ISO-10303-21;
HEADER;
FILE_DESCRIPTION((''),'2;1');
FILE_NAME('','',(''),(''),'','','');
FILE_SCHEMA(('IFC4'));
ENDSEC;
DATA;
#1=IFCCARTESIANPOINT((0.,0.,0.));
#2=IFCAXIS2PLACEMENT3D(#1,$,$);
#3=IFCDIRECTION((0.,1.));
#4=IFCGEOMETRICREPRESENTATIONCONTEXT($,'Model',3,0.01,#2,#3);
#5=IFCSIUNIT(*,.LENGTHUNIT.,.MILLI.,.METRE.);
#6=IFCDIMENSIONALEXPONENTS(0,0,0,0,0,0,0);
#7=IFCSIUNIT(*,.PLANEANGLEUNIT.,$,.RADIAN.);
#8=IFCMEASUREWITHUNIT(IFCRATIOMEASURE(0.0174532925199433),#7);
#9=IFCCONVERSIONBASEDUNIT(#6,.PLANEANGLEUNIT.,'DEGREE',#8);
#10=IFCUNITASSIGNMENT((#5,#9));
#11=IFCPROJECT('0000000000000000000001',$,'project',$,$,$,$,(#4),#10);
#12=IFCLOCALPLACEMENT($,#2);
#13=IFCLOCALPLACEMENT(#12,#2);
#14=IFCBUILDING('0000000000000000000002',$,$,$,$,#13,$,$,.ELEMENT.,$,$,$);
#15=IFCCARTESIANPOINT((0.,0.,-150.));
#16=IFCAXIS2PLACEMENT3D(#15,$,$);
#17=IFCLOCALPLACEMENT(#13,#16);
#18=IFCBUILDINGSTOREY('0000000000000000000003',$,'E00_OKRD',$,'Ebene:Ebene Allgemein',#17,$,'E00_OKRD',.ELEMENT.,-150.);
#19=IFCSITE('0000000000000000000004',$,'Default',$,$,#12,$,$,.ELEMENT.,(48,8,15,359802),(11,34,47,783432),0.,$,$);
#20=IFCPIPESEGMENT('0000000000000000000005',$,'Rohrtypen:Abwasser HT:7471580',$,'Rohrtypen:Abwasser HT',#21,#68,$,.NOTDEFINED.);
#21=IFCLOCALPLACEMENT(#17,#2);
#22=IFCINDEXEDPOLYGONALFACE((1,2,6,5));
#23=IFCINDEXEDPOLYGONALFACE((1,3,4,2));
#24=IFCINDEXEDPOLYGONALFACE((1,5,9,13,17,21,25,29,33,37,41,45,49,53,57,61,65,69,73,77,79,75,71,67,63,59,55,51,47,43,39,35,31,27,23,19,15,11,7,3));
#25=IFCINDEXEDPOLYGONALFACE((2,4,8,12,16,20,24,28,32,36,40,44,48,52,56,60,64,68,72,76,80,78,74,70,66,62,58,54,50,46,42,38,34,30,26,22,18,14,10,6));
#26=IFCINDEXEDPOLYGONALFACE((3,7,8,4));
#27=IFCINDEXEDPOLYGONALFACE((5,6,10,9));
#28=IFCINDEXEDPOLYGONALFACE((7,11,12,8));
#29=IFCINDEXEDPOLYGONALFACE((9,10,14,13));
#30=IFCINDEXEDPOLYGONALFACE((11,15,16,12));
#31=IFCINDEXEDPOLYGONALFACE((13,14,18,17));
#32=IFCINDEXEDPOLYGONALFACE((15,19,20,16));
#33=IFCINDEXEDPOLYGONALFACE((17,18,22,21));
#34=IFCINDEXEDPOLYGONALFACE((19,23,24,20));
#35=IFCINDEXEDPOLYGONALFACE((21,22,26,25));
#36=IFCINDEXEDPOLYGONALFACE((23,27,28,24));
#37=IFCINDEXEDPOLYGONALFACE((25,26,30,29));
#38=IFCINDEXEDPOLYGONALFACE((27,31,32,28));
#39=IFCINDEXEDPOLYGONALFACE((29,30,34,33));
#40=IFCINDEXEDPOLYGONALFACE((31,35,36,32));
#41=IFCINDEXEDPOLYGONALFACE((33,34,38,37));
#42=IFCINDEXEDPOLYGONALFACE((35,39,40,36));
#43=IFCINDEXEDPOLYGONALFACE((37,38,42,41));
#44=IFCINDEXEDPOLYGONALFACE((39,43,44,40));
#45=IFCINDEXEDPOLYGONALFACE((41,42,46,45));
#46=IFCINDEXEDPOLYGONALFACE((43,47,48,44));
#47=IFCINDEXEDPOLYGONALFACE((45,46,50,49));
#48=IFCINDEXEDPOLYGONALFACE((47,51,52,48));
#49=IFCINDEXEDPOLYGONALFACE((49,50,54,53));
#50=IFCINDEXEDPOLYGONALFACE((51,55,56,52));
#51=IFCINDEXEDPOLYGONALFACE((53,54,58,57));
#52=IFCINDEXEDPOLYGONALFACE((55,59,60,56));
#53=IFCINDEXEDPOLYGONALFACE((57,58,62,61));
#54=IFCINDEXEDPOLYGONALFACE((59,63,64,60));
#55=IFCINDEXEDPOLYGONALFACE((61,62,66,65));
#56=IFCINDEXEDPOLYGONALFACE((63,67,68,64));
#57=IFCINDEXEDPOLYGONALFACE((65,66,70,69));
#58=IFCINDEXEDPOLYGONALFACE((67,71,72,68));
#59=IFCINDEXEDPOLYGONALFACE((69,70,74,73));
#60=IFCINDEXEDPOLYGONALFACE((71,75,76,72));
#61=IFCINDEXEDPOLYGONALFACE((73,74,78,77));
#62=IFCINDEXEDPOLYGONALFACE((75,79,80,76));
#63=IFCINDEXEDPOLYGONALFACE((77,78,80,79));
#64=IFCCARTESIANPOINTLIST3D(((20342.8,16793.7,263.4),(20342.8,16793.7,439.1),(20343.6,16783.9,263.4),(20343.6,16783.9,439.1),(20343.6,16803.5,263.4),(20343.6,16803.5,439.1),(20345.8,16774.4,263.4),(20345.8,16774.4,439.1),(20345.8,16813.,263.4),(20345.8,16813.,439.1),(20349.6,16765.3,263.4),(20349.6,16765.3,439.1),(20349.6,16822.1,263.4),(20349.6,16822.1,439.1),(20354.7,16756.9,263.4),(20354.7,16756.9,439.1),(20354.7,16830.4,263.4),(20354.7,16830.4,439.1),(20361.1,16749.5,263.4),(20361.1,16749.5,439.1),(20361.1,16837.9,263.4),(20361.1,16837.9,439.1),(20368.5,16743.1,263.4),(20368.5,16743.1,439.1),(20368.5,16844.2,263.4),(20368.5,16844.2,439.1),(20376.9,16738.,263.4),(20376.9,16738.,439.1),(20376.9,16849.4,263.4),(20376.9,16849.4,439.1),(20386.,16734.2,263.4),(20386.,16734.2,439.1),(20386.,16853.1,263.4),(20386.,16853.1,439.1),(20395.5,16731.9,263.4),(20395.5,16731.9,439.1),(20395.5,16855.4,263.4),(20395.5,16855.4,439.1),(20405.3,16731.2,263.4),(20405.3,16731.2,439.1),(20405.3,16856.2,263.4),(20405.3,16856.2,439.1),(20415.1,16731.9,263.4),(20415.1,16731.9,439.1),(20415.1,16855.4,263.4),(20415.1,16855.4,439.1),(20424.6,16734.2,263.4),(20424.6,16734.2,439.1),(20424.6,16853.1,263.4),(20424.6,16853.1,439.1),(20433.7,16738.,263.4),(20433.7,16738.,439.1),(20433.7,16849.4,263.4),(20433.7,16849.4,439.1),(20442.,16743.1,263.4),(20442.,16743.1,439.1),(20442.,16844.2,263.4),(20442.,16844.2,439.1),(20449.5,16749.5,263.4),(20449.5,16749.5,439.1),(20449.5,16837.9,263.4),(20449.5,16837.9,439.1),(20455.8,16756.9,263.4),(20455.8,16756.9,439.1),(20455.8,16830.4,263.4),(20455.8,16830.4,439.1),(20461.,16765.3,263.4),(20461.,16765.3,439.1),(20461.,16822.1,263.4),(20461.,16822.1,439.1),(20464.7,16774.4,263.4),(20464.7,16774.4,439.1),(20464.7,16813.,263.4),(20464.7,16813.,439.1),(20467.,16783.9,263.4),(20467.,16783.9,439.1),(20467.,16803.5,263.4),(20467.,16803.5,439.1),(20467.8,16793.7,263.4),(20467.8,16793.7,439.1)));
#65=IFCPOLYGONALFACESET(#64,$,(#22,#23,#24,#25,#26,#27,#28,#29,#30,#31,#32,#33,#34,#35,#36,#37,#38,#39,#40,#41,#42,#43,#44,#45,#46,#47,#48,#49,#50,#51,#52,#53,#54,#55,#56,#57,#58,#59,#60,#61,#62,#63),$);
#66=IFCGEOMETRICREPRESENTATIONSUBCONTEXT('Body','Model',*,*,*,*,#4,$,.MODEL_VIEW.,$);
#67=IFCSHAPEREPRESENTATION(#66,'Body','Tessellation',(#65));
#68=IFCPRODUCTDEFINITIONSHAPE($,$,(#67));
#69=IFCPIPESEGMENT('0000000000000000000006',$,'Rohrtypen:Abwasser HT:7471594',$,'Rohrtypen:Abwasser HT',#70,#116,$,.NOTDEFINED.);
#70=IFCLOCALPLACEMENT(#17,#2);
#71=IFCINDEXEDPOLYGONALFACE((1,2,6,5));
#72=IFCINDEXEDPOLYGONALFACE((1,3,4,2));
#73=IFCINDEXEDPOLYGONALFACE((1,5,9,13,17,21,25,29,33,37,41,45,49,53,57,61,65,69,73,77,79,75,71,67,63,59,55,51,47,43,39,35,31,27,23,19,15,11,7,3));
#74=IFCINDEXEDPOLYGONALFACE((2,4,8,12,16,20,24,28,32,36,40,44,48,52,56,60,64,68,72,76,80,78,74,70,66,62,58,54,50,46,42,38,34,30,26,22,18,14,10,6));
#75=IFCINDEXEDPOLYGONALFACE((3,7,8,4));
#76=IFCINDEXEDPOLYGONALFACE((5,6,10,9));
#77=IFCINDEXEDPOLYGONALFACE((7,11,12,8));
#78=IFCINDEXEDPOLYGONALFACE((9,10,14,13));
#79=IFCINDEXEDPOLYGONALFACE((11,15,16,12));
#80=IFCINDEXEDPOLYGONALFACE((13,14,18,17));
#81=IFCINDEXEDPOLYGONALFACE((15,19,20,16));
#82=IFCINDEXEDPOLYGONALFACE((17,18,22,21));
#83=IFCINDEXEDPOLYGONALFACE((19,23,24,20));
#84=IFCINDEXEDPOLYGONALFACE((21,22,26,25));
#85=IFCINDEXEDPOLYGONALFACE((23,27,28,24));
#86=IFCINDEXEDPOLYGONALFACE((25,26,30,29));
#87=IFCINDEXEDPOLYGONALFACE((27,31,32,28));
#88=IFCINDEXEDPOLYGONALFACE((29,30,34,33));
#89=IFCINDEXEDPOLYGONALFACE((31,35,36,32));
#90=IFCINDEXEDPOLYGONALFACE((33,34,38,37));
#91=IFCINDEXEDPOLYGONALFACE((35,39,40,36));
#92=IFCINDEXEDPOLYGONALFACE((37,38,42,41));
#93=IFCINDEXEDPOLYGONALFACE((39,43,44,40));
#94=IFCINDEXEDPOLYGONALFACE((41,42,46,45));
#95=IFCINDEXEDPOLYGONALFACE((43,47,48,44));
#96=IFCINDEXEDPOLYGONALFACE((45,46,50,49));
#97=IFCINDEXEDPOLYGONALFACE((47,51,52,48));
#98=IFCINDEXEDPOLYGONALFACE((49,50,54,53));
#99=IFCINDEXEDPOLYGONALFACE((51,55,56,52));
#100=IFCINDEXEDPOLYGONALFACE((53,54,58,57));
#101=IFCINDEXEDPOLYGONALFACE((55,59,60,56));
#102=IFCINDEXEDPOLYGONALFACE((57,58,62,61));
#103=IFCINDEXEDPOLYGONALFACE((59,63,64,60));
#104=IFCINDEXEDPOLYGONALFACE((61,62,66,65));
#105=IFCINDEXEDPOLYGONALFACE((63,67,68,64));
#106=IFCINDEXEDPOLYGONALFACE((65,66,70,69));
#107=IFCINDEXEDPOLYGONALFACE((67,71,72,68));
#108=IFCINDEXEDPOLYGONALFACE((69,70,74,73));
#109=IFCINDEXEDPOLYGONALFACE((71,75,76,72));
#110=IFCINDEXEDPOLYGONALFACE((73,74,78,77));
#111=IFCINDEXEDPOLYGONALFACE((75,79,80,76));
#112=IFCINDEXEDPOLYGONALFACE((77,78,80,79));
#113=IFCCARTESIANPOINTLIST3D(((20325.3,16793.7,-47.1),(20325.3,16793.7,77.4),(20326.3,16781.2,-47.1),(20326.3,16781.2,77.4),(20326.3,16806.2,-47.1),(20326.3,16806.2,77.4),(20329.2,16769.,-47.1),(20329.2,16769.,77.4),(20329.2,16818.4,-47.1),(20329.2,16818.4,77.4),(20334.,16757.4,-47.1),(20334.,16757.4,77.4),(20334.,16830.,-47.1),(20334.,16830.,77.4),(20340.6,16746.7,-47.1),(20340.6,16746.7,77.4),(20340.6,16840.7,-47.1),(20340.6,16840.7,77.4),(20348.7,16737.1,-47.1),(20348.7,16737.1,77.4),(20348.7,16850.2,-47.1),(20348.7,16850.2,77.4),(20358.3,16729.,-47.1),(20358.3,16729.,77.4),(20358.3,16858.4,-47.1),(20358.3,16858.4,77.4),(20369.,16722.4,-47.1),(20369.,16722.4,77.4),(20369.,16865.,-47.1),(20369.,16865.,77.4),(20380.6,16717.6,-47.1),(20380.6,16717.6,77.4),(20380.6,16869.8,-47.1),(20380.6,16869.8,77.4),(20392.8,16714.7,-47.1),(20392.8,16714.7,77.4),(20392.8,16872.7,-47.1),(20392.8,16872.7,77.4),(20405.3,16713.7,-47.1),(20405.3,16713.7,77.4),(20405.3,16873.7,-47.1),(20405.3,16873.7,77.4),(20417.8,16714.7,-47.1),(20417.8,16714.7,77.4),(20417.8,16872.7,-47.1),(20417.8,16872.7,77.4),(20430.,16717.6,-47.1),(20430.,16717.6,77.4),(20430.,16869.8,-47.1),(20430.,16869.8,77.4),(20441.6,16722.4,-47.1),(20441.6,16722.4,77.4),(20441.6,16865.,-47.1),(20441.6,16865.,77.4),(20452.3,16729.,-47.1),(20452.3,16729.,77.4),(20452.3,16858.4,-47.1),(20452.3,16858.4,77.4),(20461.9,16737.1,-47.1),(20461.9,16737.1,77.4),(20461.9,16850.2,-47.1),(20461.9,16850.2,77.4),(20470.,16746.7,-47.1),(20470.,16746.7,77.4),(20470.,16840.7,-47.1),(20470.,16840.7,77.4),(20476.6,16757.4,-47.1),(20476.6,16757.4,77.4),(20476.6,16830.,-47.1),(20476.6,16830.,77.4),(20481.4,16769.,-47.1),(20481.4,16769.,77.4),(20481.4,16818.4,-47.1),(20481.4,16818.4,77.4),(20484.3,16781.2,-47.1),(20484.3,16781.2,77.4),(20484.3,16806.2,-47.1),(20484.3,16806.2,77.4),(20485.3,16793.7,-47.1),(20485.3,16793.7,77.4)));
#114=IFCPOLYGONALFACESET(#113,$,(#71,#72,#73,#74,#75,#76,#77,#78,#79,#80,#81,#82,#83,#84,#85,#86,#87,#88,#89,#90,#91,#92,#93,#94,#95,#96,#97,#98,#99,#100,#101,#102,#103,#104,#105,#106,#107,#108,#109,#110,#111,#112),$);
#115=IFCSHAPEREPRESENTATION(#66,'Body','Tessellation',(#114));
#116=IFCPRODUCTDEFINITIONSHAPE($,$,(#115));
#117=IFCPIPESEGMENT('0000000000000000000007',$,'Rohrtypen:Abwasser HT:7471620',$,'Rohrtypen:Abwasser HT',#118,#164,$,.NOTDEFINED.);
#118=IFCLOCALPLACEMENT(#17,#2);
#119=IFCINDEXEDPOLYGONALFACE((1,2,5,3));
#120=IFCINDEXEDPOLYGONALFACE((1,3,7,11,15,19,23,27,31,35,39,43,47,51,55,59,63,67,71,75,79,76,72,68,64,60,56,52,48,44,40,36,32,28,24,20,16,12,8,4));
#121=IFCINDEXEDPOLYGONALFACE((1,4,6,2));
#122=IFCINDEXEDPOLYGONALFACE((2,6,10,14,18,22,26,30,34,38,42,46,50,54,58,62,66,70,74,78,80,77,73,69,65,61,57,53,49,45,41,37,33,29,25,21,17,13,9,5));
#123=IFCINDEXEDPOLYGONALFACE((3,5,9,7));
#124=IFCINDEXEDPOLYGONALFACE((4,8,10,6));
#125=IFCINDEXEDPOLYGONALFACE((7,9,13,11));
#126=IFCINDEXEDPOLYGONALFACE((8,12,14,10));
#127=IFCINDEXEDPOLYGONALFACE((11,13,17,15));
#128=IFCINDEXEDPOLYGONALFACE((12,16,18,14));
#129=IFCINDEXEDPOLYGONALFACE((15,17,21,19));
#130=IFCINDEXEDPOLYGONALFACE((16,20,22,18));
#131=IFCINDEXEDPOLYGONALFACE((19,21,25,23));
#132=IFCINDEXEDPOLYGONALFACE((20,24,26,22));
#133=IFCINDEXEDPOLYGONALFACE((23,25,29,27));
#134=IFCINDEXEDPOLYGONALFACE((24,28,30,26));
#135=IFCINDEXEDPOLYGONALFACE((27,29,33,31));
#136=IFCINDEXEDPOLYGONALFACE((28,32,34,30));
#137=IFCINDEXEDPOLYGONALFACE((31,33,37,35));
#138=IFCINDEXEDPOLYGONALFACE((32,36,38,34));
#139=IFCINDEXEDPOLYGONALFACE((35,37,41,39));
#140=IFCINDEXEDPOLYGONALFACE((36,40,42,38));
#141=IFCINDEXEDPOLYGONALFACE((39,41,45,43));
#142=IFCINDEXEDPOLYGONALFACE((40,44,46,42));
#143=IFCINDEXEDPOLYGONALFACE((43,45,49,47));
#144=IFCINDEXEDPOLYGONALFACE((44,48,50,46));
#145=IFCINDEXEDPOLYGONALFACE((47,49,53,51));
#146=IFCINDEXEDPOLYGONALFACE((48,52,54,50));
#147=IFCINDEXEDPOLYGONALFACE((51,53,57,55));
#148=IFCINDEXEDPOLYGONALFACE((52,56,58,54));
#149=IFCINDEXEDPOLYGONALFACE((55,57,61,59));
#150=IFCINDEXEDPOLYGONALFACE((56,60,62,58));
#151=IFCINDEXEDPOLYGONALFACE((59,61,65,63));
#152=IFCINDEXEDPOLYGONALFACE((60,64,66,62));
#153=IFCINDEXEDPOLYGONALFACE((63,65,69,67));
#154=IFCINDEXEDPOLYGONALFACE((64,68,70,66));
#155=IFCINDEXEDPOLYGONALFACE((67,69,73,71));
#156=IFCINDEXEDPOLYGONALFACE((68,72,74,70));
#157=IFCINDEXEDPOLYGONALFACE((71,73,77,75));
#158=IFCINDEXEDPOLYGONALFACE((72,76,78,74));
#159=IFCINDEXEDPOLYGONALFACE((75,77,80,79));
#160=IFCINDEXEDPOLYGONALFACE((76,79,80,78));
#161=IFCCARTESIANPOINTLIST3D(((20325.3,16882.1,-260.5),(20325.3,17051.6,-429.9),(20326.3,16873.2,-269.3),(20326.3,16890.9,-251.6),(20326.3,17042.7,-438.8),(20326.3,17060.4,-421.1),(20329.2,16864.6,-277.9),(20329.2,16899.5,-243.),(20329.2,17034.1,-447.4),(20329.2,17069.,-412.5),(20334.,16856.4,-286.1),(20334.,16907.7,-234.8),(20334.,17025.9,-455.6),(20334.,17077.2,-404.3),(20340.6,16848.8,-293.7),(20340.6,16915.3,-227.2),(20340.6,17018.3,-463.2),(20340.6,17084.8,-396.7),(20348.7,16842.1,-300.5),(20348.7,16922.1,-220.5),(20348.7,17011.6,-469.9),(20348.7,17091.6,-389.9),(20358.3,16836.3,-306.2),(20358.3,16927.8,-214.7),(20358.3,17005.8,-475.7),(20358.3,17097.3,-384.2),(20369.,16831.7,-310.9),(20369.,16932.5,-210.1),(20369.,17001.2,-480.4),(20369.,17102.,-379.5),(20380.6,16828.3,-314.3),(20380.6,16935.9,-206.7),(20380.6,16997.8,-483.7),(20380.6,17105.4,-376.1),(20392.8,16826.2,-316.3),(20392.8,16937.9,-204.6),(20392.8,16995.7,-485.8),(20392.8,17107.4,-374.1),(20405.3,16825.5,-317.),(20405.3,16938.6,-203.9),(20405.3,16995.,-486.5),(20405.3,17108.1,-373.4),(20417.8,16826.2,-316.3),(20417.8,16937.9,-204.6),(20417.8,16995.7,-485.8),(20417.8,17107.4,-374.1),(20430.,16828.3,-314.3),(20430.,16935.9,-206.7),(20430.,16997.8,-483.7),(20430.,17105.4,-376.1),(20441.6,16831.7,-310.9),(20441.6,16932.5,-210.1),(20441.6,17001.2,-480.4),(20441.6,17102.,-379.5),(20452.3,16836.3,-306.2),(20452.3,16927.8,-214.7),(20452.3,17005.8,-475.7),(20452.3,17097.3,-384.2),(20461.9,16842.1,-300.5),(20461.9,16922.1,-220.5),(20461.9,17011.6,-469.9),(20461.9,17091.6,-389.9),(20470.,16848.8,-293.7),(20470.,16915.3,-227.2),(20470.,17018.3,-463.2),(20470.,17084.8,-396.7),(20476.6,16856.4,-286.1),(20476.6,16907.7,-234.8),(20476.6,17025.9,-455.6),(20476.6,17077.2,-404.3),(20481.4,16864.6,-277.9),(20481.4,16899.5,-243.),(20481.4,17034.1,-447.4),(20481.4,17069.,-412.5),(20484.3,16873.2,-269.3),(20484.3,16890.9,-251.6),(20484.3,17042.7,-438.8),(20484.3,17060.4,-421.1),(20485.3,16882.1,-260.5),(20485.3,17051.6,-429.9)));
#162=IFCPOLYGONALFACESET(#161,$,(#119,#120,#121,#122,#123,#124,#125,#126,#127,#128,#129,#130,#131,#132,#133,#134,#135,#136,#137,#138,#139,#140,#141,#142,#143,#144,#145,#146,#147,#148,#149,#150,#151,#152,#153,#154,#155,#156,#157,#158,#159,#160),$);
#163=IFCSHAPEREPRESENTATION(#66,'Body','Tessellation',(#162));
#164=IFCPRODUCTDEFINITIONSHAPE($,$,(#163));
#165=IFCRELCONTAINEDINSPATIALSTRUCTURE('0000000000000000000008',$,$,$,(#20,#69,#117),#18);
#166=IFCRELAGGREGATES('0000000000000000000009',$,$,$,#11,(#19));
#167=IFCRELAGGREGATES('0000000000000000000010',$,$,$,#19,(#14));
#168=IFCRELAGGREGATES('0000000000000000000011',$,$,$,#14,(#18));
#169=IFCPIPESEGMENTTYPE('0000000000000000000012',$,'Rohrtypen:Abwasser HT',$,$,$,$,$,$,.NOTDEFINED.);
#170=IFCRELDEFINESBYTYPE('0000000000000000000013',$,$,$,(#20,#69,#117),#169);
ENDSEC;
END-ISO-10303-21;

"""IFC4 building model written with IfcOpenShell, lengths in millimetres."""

from ifc_helpers import new_model, entity, si_unit, converted_unit, direction, frame, origin, place, context, subcontext, project, spatial, indexed_curve, outline, extrude, type_object, element, save


model = new_model("IFC4")

# Units and contexts
model_context = context("Model", 3, precision=0.01, world=origin(), true_north=direction((0.0, 1.0)))
body_context = subcontext(model_context, "Body", "Model", "MODEL_VIEW")
ifc_project = project(units=[si_unit("LENGTHUNIT", "METRE", prefix="MILLI"), converted_unit("PLANEANGLEUNIT", "DEGREE", entity("IfcRatioMeasure", 0.0174532925199433), si_unit("PLANEANGLEUNIT", "RADIAN"), dimensions=[0, 0, 0, 0, 0, 0, 0])], contexts=[model_context])

# Site, building, storey
site_placement = place(None, origin())
site = spatial("IfcSite", under=ifc_project, at=site_placement, Name="Default", CompositionType="ELEMENT", RefLatitude=(48, 8, 15, 359802), RefLongitude=(11, 34, 47, 783432), RefElevation=0.0)
building_placement = place(site_placement, origin())
building = spatial("IfcBuilding", under=site, at=building_placement, CompositionType="ELEMENT")
storey_placement = place(building_placement, frame((0.0, 0.0, -150.0)))
storey = spatial("IfcBuildingStorey", under=building, at=storey_placement, Name="E00_OKRD", ObjectType="Ebene:Ebene Allgemein", LongName="E00_OKRD", CompositionType="ELEMENT", Elevation=-150.0)

# Pipe segments
pipe_segment_type_1 = type_object("IfcPipeSegmentType", Name="Rohrtypen:Abwasser HT", PredefinedType="NOTDEFINED")
pipe_segment_1_placement = place(storey_placement, origin())
element("IfcPipeSegment", 1, at=pipe_segment_1_placement, inside=storey, type_object=pipe_segment_type_1, Name="Rohrtypen:Abwasser HT:7471580", ObjectType="Rohrtypen:Abwasser HT", PredefinedType="NOTDEFINED", context=body_context, shape_type="SweptSolid", body=[
    extrude(outline(indexed_curve([(62.5, 0.0), (61.7, 9.8), (59.4, 19.3), (55.7, 28.4), (50.6, 36.7), (44.2, 44.2), (36.7, 50.6), (28.4, 55.7), (19.3, 59.4), (9.8, 61.7), (0.0, 62.5), (-9.8, 61.7), (-19.3, 59.4), (-28.4, 55.7), (-36.7, 50.6), (-44.2, 44.2), (-50.6, 36.7), (-55.7, 28.4), (-59.4, 19.3), (-61.7, 9.8), (-62.5, 0.0), (-61.7, -9.8), (-59.4, -19.3), (-55.7, -28.4), (-50.6, -36.7), (-44.2, -44.2), (-36.7, -50.6), (-28.4, -55.7), (-19.3, -59.4), (-9.8, -61.7), (0.0, -62.5), (9.8, -61.7), (19.3, -59.4), (28.4, -55.7), (36.7, -50.6), (44.2, -44.2), (50.6, -36.7), (55.7, -28.4), (59.4, -19.3), (61.7, -9.8), (62.5, 0.0)], self_intersect=False)), frame((20405.3, 16793.7, 263.4)), (0.0, 0.0, 1.0), 175.7),
])
pipe_segment_2_placement = place(storey_placement, origin())
element("IfcPipeSegment", 2, at=pipe_segment_2_placement, inside=storey, type_object=pipe_segment_type_1, Name="Rohrtypen:Abwasser HT:7471594", ObjectType="Rohrtypen:Abwasser HT", PredefinedType="NOTDEFINED", context=body_context, shape_type="SweptSolid", body=[
    extrude(outline(indexed_curve([(80.0, 0.0), (79.0, 12.5), (76.1, 24.7), (71.3, 36.3), (64.7, 47.0), (56.6, 56.6), (47.0, 64.7), (36.3, 71.3), (24.7, 76.1), (12.5, 79.0), (0.0, 80.0), (-12.5, 79.0), (-24.7, 76.1), (-36.3, 71.3), (-47.0, 64.7), (-56.6, 56.6), (-64.7, 47.0), (-71.3, 36.3), (-76.1, 24.7), (-79.0, 12.5), (-80.0, 0.0), (-79.0, -12.5), (-76.1, -24.7), (-71.3, -36.3), (-64.7, -47.0), (-56.6, -56.6), (-47.0, -64.7), (-36.3, -71.3), (-24.7, -76.1), (-12.5, -79.0), (0.0, -80.0), (12.5, -79.0), (24.7, -76.1), (36.3, -71.3), (47.0, -64.7), (56.6, -56.6), (64.7, -47.0), (71.3, -36.3), (76.1, -24.7), (79.0, -12.5), (80.0, 0.0)], self_intersect=False)), frame((20405.3, 16793.7, -47.1)), (0.0, 0.0, 1.0), 124.5),
])
pipe_segment_3_placement = place(storey_placement, origin())
element("IfcPipeSegment", 3, at=pipe_segment_3_placement, inside=storey, type_object=pipe_segment_type_1, Name="Rohrtypen:Abwasser HT:7471620", ObjectType="Rohrtypen:Abwasser HT", PredefinedType="NOTDEFINED", context=body_context, shape_type="SweptSolid", body=[
    extrude(outline(indexed_curve([(80.0, 0.0), (79.0, 12.5), (76.1, 24.7), (71.3, 36.3), (64.7, 47.0), (56.6, 56.6), (47.0, 64.7), (36.3, 71.3), (24.7, 76.1), (12.5, 79.0), (0.0, 80.0), (-12.5, 79.0), (-24.7, 76.1), (-36.3, 71.3), (-47.0, 64.7), (-56.6, 56.6), (-64.7, 47.0), (-71.3, 36.3), (-76.1, 24.7), (-79.0, 12.5), (-80.0, 0.0), (-79.0, -12.5), (-76.1, -24.7), (-71.3, -36.3), (-64.7, -47.0), (-56.6, -56.6), (-47.0, -64.7), (-36.3, -71.3), (-24.7, -76.1), (-12.5, -79.0), (0.0, -80.0), (12.5, -79.0), (24.7, -76.1), (36.3, -71.3), (47.0, -64.7), (56.6, -56.6), (64.7, -47.0), (71.3, -36.3), (76.1, -24.7), (79.0, -12.5), (80.0, 0.0)], self_intersect=False)), frame((20405.3, 16882.1, -260.5), z_axis=(0.0, 0.707107, -0.707107), x_axis=(1.0, 0.0, 0.0)), (0.0, 0.0, 1.0), 239.7),
])

save(model, "model.ifc")
